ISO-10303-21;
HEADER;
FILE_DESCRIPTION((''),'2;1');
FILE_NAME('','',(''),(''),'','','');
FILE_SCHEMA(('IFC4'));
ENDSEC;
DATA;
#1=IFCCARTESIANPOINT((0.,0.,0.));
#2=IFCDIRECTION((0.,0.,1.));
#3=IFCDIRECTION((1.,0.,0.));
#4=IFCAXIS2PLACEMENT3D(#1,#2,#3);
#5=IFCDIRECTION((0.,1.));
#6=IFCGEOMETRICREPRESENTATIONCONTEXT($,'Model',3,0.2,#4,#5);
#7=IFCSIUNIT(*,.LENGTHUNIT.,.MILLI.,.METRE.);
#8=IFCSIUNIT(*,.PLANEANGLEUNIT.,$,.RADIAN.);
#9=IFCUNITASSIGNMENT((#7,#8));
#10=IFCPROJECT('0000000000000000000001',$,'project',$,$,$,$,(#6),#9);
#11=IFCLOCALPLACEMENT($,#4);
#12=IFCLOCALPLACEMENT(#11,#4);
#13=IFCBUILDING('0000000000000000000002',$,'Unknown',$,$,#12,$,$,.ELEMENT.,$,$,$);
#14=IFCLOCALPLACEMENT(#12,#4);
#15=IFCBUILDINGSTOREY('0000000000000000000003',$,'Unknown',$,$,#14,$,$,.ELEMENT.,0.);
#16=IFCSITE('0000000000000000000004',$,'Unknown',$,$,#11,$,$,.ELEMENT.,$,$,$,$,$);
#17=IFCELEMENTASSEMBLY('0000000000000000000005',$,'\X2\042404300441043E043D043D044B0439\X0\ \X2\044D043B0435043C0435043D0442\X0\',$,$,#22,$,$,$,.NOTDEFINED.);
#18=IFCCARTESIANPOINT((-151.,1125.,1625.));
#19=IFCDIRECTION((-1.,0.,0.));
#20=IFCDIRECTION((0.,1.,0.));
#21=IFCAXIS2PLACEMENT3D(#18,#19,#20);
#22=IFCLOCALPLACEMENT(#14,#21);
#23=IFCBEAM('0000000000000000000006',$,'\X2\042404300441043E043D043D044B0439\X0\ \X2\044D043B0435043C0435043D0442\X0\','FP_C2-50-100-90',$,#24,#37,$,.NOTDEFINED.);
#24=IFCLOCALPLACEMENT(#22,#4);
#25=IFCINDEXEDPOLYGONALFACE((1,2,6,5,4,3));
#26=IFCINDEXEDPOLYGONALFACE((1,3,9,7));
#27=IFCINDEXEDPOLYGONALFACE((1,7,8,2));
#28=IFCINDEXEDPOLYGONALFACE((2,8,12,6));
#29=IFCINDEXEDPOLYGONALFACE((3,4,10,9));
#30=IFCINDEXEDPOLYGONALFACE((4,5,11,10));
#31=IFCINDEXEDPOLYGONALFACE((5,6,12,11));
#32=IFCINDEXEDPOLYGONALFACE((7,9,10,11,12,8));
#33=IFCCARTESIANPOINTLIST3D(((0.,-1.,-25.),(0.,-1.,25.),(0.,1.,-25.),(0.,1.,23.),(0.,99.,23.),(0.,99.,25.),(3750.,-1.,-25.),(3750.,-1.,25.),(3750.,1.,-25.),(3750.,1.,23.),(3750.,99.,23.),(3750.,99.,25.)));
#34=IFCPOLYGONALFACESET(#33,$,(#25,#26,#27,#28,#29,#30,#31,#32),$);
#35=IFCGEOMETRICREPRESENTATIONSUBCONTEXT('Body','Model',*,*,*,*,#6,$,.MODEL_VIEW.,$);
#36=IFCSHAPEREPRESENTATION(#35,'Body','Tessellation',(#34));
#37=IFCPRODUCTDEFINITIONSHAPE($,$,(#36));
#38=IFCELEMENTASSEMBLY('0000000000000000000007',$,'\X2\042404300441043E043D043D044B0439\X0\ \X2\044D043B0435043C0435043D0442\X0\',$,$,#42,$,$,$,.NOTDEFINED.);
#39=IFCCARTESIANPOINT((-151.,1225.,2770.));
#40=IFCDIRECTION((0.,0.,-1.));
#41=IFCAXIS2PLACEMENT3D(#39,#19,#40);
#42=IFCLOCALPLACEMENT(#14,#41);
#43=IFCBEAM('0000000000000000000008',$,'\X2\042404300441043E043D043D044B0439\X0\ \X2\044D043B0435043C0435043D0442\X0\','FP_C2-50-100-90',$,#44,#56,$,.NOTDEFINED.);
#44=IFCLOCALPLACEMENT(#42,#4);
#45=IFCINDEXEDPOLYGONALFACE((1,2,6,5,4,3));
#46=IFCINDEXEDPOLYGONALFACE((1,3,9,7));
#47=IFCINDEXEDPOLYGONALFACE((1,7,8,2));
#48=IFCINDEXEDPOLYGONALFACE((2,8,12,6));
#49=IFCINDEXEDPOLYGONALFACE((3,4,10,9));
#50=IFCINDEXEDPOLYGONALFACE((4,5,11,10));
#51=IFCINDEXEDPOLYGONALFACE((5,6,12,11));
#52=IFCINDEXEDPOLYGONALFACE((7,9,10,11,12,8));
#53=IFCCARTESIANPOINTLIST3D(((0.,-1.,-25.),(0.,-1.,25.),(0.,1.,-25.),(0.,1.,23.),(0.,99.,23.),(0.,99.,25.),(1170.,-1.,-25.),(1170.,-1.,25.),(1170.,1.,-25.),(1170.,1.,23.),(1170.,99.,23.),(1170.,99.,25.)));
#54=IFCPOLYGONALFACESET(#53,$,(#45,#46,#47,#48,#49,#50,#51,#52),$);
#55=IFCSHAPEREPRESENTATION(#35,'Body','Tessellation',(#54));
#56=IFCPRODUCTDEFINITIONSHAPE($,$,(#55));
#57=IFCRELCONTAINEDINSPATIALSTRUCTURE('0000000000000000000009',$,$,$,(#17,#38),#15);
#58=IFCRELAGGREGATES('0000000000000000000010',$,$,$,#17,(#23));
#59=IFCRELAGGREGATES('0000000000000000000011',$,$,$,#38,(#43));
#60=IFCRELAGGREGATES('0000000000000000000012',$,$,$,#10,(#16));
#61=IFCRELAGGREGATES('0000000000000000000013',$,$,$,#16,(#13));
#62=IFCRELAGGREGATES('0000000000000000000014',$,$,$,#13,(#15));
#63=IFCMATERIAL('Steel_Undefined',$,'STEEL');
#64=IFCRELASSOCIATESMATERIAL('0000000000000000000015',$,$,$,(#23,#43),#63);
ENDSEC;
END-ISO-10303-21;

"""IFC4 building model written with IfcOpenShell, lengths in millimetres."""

from ifc_helpers import new_model, si_unit, direction, frame, origin_with_axes, place, context, subcontext, project, spatial, line, indexed_curve, outline, extrude, material, element, aggregate, save


model = new_model("IFC4")

# Units and contexts
model_context = context("Model", 3, precision=0.2, world=origin_with_axes(), true_north=direction((0.0, 1.0)))
body_context = subcontext(model_context, "Body", "Model", "MODEL_VIEW")
ifc_project = project(units=[si_unit("LENGTHUNIT", "METRE", prefix="MILLI"), si_unit("PLANEANGLEUNIT", "RADIAN")], contexts=[model_context])

# Site, building, storey
site_placement = place(None, origin_with_axes())
site = spatial("IfcSite", under=ifc_project, at=site_placement, Name="Unknown", CompositionType="ELEMENT")
building_placement = place(site_placement, origin_with_axes())
building = spatial("IfcBuilding", under=site, at=building_placement, Name="Unknown", CompositionType="ELEMENT")
storey_placement = place(building_placement, origin_with_axes())
storey = spatial("IfcBuildingStorey", under=building, at=storey_placement, Name="Unknown", CompositionType="ELEMENT", Elevation=0.0)

# Shared definitions
ifc_material_1 = material(Name="Steel_Undefined", Category="STEEL")

# Element assemblies, beams
assembly_1_placement = place(storey_placement, frame((-151.0, 1125.0, 1625.0), z_axis=(-1.0, 0.0, 0.0), x_axis=(0.0, 1.0, 0.0)))
assembly_1 = element("IfcElementAssembly", 1, at=assembly_1_placement, inside=storey, Name="Фасонный элемент", PredefinedType="NOTDEFINED")
beam_1_placement = place(assembly_1_placement, origin_with_axes())
beam_1 = element("IfcBeam", 2, at=beam_1_placement, material=ifc_material_1, Name="Фасонный элемент", Description="FP_C2-50-100-90", PredefinedType="NOTDEFINED", context=body_context, shape_type="SolidModel", body=[
    extrude(outline(indexed_curve([(-25.0, -1.0), (25.0, -1.0), (25.0, 99.0), (23.0, 99.0), (23.0, 1.0), (-25.0, 1.0)], segments=[line(1, 2, 3, 4, 5, 6, 1)])), frame((0.0, 0.0, 0.0), z_axis=(-1.0, 0.0, 0.0), x_axis=(0.0, 0.0, 1.0)), (0.0, 0.0, -1.0), 3750.0),
])
aggregate(assembly_1, [beam_1])
assembly_2_placement = place(storey_placement, frame((-151.0, 1225.0, 2770.0), z_axis=(-1.0, 0.0, 0.0), x_axis=(0.0, 0.0, -1.0)))
assembly_2 = element("IfcElementAssembly", 3, at=assembly_2_placement, inside=storey, Name="Фасонный элемент", PredefinedType="NOTDEFINED")
beam_2_placement = place(assembly_2_placement, origin_with_axes())
beam_2 = element("IfcBeam", 4, at=beam_2_placement, material=ifc_material_1, Name="Фасонный элемент", Description="FP_C2-50-100-90", PredefinedType="NOTDEFINED", context=body_context, shape_type="SolidModel", body=[
    extrude(outline(indexed_curve([(-25.0, -1.0), (25.0, -1.0), (25.0, 99.0), (23.0, 99.0), (23.0, 1.0), (-25.0, 1.0)], segments=[line(1, 2, 3, 4, 5, 6, 1)])), frame((0.0, 0.0, 0.0), z_axis=(-1.0, 0.0, 0.0), x_axis=(0.0, 0.0, 1.0)), (0.0, 0.0, -1.0), 1170.0),
])
aggregate(assembly_2, [beam_2])

save(model, "model.ifc")
